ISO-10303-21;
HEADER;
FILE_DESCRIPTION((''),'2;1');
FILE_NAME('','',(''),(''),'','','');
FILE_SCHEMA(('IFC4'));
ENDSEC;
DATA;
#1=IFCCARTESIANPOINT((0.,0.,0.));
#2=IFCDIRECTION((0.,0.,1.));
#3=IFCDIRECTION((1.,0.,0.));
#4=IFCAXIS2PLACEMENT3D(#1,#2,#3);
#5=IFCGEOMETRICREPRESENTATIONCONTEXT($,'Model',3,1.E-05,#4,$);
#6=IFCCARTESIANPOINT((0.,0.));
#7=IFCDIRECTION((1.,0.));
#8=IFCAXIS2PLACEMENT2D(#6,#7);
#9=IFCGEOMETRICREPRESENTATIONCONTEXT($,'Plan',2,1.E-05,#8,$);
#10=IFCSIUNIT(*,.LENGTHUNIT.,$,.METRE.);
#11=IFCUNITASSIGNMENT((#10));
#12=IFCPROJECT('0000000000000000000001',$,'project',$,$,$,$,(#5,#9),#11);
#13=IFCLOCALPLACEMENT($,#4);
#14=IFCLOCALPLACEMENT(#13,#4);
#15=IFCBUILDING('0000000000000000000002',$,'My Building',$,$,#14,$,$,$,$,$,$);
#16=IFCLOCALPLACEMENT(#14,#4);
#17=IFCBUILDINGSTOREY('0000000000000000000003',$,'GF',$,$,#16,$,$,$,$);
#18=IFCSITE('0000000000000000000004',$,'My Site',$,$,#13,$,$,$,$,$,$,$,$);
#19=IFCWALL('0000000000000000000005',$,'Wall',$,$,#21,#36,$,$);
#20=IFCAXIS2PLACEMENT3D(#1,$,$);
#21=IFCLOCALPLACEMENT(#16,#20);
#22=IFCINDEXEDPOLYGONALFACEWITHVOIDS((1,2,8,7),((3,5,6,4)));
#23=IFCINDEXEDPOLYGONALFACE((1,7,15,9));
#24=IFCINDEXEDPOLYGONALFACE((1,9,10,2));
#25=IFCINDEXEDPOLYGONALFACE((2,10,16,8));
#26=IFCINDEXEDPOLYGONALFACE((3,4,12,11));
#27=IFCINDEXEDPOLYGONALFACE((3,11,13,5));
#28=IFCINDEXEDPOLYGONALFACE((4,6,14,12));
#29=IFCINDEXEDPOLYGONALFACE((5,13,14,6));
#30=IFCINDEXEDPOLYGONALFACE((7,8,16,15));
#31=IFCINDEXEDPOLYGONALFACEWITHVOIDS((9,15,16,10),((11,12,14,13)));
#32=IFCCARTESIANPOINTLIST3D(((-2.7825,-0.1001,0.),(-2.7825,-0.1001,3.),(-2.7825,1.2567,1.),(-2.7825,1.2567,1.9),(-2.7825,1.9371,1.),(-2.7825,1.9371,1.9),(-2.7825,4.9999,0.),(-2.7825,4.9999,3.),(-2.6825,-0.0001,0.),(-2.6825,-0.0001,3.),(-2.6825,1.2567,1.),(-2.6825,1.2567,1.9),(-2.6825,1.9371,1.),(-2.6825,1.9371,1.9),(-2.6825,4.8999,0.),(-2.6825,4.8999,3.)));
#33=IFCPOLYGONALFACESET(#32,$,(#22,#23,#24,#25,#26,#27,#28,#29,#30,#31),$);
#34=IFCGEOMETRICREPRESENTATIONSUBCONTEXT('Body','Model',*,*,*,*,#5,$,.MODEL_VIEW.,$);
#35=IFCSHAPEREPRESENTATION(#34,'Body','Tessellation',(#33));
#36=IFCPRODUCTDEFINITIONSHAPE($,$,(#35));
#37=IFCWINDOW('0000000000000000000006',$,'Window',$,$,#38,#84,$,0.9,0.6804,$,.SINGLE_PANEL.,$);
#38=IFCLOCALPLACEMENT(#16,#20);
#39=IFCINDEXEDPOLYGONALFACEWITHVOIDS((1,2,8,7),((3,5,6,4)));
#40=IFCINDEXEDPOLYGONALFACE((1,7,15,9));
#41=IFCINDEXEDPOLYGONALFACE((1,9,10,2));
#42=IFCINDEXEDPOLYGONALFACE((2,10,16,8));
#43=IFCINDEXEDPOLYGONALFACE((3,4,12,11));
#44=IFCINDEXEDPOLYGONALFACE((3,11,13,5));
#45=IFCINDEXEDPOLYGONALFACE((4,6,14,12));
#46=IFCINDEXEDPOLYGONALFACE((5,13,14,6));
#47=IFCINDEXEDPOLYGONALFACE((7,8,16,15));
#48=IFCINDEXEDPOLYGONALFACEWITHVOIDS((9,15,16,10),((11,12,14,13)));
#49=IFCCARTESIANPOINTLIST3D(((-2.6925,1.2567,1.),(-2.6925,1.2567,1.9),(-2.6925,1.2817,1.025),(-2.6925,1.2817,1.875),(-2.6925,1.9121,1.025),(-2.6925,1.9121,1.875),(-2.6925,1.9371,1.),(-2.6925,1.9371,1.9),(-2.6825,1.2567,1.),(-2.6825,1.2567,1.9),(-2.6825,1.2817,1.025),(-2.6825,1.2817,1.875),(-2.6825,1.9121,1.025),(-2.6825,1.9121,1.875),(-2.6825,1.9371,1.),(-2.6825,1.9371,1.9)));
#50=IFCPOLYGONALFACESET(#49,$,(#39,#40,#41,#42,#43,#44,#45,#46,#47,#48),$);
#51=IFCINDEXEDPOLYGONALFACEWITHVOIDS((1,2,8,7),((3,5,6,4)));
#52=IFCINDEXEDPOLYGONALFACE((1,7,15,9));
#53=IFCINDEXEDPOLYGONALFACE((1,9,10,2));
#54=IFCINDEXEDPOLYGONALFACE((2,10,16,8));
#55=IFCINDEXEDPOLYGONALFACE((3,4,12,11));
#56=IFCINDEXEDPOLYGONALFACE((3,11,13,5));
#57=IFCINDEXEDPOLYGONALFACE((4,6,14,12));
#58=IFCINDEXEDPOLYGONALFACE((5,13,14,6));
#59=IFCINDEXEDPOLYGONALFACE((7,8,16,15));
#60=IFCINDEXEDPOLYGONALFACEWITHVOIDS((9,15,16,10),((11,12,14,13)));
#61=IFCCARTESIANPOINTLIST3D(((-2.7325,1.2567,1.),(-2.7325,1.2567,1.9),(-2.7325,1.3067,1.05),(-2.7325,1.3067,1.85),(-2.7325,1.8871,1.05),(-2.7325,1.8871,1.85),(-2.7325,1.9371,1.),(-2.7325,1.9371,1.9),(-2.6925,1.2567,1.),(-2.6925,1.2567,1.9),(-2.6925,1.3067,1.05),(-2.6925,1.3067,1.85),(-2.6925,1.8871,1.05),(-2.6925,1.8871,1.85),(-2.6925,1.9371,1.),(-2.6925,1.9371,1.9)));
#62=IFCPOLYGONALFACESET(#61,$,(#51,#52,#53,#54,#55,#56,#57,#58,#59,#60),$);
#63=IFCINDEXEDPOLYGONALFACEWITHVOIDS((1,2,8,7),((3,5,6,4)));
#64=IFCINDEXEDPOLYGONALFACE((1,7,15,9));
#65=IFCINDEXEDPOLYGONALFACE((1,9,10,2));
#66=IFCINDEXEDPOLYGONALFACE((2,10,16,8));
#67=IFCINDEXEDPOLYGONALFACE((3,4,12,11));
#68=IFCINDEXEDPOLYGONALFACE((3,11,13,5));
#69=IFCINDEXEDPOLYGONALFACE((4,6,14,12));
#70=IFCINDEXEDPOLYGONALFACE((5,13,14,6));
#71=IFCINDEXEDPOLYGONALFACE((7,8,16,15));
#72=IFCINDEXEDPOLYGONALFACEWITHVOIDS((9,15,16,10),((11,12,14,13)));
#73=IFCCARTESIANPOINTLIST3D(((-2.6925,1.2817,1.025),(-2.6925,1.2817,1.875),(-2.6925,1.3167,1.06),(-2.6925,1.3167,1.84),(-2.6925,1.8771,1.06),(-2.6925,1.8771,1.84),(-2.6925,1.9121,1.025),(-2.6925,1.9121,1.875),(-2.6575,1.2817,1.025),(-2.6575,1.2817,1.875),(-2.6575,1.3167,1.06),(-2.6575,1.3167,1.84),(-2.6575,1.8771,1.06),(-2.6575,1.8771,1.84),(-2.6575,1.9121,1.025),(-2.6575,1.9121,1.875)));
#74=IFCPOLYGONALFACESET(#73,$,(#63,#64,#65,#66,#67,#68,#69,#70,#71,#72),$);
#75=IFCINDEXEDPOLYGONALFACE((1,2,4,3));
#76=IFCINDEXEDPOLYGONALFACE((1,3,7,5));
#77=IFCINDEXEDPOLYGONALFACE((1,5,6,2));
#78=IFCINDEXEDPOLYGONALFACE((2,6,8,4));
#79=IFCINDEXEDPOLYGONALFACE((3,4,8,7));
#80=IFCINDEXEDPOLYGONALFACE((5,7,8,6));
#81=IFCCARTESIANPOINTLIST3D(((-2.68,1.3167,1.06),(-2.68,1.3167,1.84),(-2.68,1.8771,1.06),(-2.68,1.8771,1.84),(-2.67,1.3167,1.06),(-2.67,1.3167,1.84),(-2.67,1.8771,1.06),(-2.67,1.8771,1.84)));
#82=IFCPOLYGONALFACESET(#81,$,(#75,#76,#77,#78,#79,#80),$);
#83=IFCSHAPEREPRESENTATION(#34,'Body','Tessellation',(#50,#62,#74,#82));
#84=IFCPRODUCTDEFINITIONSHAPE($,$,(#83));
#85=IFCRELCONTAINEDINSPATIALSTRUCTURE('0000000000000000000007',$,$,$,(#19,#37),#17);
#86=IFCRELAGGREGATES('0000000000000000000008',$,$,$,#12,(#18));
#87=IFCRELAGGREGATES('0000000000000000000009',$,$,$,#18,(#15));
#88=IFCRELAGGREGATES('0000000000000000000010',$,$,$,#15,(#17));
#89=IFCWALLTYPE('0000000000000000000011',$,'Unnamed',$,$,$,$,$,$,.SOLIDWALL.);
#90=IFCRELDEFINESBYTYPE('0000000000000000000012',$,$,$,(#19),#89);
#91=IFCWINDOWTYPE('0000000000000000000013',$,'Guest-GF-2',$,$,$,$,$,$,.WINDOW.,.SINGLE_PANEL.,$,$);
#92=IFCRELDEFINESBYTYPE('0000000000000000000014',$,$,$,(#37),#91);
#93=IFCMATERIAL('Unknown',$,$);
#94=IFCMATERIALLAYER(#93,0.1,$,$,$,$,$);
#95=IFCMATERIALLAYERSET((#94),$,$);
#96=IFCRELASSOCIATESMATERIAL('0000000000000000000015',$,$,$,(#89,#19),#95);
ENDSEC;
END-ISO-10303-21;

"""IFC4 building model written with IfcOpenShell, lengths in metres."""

from ifc_helpers import new_model, entity, si_unit, frame, origin_with_axes, origin_2d_with_axis, place, context, subcontext, project, spatial, line, indexed_curve, outline, extrude, shape, source, transform, mapped, material, layer, layer_set, layer_usage, type_object, type_shapes, element, fill, save


model = new_model("IFC4")

# Units and contexts
model_context = context("Model", 3, precision=1e-05, world=origin_with_axes())
plan_context = context("Plan", 2, precision=1e-05, world=origin_2d_with_axis())
body_context_1 = subcontext(model_context, "Body", "Model", "MODEL_VIEW")
body_context_2 = subcontext(plan_context, "Body", "Plan", "PLAN_VIEW")
ifc_project = project(units=[si_unit("LENGTHUNIT", "METRE")], contexts=[model_context, plan_context])

# Site, building, storey
site_placement = place(None, origin_with_axes())
site = spatial("IfcSite", under=ifc_project, at=site_placement, Name="My Site")
building_placement = place(site_placement, origin_with_axes())
building = spatial("IfcBuilding", under=site, at=building_placement, Name="My Building")
storey_placement = place(building_placement, origin_with_axes())
storey = spatial("IfcBuildingStorey", under=building, at=storey_placement, Name="GF")

# Shared definitions
ifc_material = material(Name="Unknown")

# Shared definitions
ifc_layer_1 = layer(ifc_material, 0.1)
ifc_layer_set_1 = layer_set([ifc_layer_1])
wall_type = type_object("IfcWallType", Name="Unnamed", PredefinedType="SOLIDWALL", material=ifc_layer_set_1)

# Wall, opening, window
ifc_layer_usage_1 = layer_usage(ifc_layer_set_1, "AXIS2", "POSITIVE", 0.0)
wall_1_placement = place(storey_placement, frame((-2.7825, 4.9999, 0.0), z_axis=(0.0, 0.0, 1.0), x_axis=(0.0, -1.0, 0.0)))
wall_1 = element("IfcWall", 1, at=wall_1_placement, inside=storey, type_object=wall_type, material=ifc_layer_usage_1, Name="Wall", context=body_context_1, shape_type="SweptSolid", body=[
    extrude(outline(indexed_curve([(0.0, 0.0), (0.1, 0.1), (5.0, 0.1), (5.1, 0.0)], segments=[line(1, 2, 3, 4, 1)])), origin_with_axes(), (0.0, 0.0, 1.0), 3.0),
])
shared_shape_1 = source(origin_with_axes(), body_context_1, "Body", "SweptSolid", [
    extrude(outline(indexed_curve([(0.0, 0.0), (0.6804, 0.0), (0.6804, 0.9), (0.0, 0.9)], segments=[line(1, 2, 3, 4, 1)])), frame((0.0, -0.6, 0.0), z_axis=(0.0, -1.0, 0.0), x_axis=(1.0, 0.0, 0.0)), (0.0, 0.0, -1.0), 1.2),
])
opening_1_placement = place(wall_1_placement, frame((3.0629, 0.0, 1.0), z_axis=(0.0, 0.0, 1.0), x_axis=(1.0, 0.0, 0.0)))
opening_1 = element("IfcOpeningElement", 2, at=opening_1_placement, cuts=wall_1, PredefinedType="OPENING", context=body_context_1, shape_type="MappedRepresentation", body=[
    mapped(shared_shape_1, transform((0.0, 0.0, 0.0), x_axis=(1.0, 0.0, 0.0), y_axis=(0.0, 1.0, 0.0), z_axis=(0.0, 0.0, 1.0), scale=1.0)),
])
window_type_1 = type_object("IfcWindowType", Name="Guest-GF-2", PartitioningType="SINGLE_PANEL", PredefinedType="WINDOW")
shared_shape_2 = source(origin_with_axes(), body_context_1, "Body", "SweptSolid", [
    extrude(outline(indexed_curve([(0.0, 0.0), (0.6804, 0.0), (0.6804, 0.9), (0.0, 0.9)], segments=[line(1, 2, 3, 4, 1)]), holes=[indexed_curve([(0.025, 0.025), (0.6554, 0.025), (0.6554, 0.875), (0.025, 0.875)], segments=[line(1, 2, 3, 4, 1)])]), frame((0.0, 0.09, 0.0), z_axis=(0.0, -1.0, 0.0), x_axis=(1.0, 0.0, 0.0)), (0.0, 0.0, -1.0), 0.01),
    extrude(outline(indexed_curve([(0.0, 0.0), (0.6804, 0.0), (0.6804, 0.9), (0.0, 0.9)], segments=[line(1, 2, 3, 4, 1)]), holes=[indexed_curve([(0.05, 0.05), (0.6304, 0.05), (0.6304, 0.85), (0.05, 0.85)], segments=[line(1, 2, 3, 4, 1)])]), frame((0.0, 0.05, 0.0), z_axis=(0.0, -1.0, 0.0), x_axis=(1.0, 0.0, 0.0)), (0.0, 0.0, -1.0), 0.04),
    extrude(outline(indexed_curve([(0.0, 0.0), (0.6304, 0.0), (0.6304, 0.85), (0.0, 0.85)], segments=[line(1, 2, 3, 4, 1)]), holes=[indexed_curve([(0.035, 0.035), (0.5954, 0.035), (0.5954, 0.815), (0.035, 0.815)], segments=[line(1, 2, 3, 4, 1)])]), frame((0.025, 0.09, 0.025), z_axis=(0.0, -1.0, 0.0), x_axis=(1.0, 0.0, 0.0)), (0.0, 0.0, -1.0), 0.035),
    extrude(outline(indexed_curve([(0.035, 0.035), (0.5954, 0.035), (0.5954, 0.815), (0.035, 0.815)], segments=[line(1, 2, 3, 4, 1)])), frame((0.025, 0.1025, 0.025), z_axis=(0.0, -1.0, 0.0), x_axis=(1.0, 0.0, 0.0)), (0.0, 0.0, -1.0), 0.01),
])
shared_shape_3 = source(origin_with_axes(), body_context_2, "Body", "Curve2D", [
    entity("IfcIndexedPolyCurve", entity("IfcCartesianPointList2D", [[0.05, 0.05], [0.6304, 0.05]])),
    entity("IfcIndexedPolyCurve", entity("IfcCartesianPointList2D", [[0.0, 0.1], [0.025, 0.1], [0.025, 0.09], [0.05, 0.09], [0.05, 0.05], [0.0, 0.05]]), [entity("IfcLineIndex", [1, 2, 3, 4, 5, 6, 1])]),
    entity("IfcIndexedPolyCurve", entity("IfcCartesianPointList2D", [[0.6804, 0.1], [0.6554, 0.1], [0.6554, 0.09], [0.6304, 0.09], [0.6304, 0.05], [0.6804, 0.05]]), [entity("IfcLineIndex", [1, 2, 3, 4, 5, 6, 1])]),
    entity("IfcIndexedPolyCurve", entity("IfcCartesianPointList2D", [[0.025, 0.09], [0.06, 0.09], [0.06, 0.125], [0.025, 0.125]]), [entity("IfcLineIndex", [1, 2, 3, 4, 1])]),
    entity("IfcIndexedPolyCurve", entity("IfcCartesianPointList2D", [[0.6554, 0.09], [0.6204, 0.09], [0.6204, 0.125], [0.6554, 0.125]]), [entity("IfcLineIndex", [1, 2, 3, 4, 1])]),
    entity("IfcIndexedPolyCurve", entity("IfcCartesianPointList2D", [[0.06, 0.09], [0.6204, 0.09]])),
    entity("IfcIndexedPolyCurve", entity("IfcCartesianPointList2D", [[0.06, 0.125], [0.6204, 0.125]])),
    entity("IfcIndexedPolyCurve", entity("IfcCartesianPointList2D", [[0.06, 0.1075], [0.6204, 0.1075]])),
])
type_shapes(window_type_1, [shared_shape_2, shared_shape_3])
window_1_placement = place(opening_1_placement, origin_with_axes())
window_1 = element("IfcWindow", 3, at=window_1_placement, inside=storey, type_object=window_type_1, Name="Window", OverallHeight=0.9, OverallWidth=0.6804, PartitioningType="SINGLE_PANEL", shapes=[
    shape(body_context_1, "Body", "MappedRepresentation", [mapped(shared_shape_2, transform((0.0, 0.0, 0.0), x_axis=(1.0, 0.0, 0.0), y_axis=(0.0, 1.0, 0.0), z_axis=(0.0, 0.0, 1.0), scale=1.0))]),
    shape(body_context_2, "Body", "MappedRepresentation", [mapped(shared_shape_3, transform((0.0, 0.0, 0.0), x_axis=(1.0, 0.0, 0.0), y_axis=(0.0, 1.0, 0.0), z_axis=(0.0, 0.0, 1.0), scale=1.0))]),
])
fill(opening_1, window_1)

save(model, "model.ifc")
